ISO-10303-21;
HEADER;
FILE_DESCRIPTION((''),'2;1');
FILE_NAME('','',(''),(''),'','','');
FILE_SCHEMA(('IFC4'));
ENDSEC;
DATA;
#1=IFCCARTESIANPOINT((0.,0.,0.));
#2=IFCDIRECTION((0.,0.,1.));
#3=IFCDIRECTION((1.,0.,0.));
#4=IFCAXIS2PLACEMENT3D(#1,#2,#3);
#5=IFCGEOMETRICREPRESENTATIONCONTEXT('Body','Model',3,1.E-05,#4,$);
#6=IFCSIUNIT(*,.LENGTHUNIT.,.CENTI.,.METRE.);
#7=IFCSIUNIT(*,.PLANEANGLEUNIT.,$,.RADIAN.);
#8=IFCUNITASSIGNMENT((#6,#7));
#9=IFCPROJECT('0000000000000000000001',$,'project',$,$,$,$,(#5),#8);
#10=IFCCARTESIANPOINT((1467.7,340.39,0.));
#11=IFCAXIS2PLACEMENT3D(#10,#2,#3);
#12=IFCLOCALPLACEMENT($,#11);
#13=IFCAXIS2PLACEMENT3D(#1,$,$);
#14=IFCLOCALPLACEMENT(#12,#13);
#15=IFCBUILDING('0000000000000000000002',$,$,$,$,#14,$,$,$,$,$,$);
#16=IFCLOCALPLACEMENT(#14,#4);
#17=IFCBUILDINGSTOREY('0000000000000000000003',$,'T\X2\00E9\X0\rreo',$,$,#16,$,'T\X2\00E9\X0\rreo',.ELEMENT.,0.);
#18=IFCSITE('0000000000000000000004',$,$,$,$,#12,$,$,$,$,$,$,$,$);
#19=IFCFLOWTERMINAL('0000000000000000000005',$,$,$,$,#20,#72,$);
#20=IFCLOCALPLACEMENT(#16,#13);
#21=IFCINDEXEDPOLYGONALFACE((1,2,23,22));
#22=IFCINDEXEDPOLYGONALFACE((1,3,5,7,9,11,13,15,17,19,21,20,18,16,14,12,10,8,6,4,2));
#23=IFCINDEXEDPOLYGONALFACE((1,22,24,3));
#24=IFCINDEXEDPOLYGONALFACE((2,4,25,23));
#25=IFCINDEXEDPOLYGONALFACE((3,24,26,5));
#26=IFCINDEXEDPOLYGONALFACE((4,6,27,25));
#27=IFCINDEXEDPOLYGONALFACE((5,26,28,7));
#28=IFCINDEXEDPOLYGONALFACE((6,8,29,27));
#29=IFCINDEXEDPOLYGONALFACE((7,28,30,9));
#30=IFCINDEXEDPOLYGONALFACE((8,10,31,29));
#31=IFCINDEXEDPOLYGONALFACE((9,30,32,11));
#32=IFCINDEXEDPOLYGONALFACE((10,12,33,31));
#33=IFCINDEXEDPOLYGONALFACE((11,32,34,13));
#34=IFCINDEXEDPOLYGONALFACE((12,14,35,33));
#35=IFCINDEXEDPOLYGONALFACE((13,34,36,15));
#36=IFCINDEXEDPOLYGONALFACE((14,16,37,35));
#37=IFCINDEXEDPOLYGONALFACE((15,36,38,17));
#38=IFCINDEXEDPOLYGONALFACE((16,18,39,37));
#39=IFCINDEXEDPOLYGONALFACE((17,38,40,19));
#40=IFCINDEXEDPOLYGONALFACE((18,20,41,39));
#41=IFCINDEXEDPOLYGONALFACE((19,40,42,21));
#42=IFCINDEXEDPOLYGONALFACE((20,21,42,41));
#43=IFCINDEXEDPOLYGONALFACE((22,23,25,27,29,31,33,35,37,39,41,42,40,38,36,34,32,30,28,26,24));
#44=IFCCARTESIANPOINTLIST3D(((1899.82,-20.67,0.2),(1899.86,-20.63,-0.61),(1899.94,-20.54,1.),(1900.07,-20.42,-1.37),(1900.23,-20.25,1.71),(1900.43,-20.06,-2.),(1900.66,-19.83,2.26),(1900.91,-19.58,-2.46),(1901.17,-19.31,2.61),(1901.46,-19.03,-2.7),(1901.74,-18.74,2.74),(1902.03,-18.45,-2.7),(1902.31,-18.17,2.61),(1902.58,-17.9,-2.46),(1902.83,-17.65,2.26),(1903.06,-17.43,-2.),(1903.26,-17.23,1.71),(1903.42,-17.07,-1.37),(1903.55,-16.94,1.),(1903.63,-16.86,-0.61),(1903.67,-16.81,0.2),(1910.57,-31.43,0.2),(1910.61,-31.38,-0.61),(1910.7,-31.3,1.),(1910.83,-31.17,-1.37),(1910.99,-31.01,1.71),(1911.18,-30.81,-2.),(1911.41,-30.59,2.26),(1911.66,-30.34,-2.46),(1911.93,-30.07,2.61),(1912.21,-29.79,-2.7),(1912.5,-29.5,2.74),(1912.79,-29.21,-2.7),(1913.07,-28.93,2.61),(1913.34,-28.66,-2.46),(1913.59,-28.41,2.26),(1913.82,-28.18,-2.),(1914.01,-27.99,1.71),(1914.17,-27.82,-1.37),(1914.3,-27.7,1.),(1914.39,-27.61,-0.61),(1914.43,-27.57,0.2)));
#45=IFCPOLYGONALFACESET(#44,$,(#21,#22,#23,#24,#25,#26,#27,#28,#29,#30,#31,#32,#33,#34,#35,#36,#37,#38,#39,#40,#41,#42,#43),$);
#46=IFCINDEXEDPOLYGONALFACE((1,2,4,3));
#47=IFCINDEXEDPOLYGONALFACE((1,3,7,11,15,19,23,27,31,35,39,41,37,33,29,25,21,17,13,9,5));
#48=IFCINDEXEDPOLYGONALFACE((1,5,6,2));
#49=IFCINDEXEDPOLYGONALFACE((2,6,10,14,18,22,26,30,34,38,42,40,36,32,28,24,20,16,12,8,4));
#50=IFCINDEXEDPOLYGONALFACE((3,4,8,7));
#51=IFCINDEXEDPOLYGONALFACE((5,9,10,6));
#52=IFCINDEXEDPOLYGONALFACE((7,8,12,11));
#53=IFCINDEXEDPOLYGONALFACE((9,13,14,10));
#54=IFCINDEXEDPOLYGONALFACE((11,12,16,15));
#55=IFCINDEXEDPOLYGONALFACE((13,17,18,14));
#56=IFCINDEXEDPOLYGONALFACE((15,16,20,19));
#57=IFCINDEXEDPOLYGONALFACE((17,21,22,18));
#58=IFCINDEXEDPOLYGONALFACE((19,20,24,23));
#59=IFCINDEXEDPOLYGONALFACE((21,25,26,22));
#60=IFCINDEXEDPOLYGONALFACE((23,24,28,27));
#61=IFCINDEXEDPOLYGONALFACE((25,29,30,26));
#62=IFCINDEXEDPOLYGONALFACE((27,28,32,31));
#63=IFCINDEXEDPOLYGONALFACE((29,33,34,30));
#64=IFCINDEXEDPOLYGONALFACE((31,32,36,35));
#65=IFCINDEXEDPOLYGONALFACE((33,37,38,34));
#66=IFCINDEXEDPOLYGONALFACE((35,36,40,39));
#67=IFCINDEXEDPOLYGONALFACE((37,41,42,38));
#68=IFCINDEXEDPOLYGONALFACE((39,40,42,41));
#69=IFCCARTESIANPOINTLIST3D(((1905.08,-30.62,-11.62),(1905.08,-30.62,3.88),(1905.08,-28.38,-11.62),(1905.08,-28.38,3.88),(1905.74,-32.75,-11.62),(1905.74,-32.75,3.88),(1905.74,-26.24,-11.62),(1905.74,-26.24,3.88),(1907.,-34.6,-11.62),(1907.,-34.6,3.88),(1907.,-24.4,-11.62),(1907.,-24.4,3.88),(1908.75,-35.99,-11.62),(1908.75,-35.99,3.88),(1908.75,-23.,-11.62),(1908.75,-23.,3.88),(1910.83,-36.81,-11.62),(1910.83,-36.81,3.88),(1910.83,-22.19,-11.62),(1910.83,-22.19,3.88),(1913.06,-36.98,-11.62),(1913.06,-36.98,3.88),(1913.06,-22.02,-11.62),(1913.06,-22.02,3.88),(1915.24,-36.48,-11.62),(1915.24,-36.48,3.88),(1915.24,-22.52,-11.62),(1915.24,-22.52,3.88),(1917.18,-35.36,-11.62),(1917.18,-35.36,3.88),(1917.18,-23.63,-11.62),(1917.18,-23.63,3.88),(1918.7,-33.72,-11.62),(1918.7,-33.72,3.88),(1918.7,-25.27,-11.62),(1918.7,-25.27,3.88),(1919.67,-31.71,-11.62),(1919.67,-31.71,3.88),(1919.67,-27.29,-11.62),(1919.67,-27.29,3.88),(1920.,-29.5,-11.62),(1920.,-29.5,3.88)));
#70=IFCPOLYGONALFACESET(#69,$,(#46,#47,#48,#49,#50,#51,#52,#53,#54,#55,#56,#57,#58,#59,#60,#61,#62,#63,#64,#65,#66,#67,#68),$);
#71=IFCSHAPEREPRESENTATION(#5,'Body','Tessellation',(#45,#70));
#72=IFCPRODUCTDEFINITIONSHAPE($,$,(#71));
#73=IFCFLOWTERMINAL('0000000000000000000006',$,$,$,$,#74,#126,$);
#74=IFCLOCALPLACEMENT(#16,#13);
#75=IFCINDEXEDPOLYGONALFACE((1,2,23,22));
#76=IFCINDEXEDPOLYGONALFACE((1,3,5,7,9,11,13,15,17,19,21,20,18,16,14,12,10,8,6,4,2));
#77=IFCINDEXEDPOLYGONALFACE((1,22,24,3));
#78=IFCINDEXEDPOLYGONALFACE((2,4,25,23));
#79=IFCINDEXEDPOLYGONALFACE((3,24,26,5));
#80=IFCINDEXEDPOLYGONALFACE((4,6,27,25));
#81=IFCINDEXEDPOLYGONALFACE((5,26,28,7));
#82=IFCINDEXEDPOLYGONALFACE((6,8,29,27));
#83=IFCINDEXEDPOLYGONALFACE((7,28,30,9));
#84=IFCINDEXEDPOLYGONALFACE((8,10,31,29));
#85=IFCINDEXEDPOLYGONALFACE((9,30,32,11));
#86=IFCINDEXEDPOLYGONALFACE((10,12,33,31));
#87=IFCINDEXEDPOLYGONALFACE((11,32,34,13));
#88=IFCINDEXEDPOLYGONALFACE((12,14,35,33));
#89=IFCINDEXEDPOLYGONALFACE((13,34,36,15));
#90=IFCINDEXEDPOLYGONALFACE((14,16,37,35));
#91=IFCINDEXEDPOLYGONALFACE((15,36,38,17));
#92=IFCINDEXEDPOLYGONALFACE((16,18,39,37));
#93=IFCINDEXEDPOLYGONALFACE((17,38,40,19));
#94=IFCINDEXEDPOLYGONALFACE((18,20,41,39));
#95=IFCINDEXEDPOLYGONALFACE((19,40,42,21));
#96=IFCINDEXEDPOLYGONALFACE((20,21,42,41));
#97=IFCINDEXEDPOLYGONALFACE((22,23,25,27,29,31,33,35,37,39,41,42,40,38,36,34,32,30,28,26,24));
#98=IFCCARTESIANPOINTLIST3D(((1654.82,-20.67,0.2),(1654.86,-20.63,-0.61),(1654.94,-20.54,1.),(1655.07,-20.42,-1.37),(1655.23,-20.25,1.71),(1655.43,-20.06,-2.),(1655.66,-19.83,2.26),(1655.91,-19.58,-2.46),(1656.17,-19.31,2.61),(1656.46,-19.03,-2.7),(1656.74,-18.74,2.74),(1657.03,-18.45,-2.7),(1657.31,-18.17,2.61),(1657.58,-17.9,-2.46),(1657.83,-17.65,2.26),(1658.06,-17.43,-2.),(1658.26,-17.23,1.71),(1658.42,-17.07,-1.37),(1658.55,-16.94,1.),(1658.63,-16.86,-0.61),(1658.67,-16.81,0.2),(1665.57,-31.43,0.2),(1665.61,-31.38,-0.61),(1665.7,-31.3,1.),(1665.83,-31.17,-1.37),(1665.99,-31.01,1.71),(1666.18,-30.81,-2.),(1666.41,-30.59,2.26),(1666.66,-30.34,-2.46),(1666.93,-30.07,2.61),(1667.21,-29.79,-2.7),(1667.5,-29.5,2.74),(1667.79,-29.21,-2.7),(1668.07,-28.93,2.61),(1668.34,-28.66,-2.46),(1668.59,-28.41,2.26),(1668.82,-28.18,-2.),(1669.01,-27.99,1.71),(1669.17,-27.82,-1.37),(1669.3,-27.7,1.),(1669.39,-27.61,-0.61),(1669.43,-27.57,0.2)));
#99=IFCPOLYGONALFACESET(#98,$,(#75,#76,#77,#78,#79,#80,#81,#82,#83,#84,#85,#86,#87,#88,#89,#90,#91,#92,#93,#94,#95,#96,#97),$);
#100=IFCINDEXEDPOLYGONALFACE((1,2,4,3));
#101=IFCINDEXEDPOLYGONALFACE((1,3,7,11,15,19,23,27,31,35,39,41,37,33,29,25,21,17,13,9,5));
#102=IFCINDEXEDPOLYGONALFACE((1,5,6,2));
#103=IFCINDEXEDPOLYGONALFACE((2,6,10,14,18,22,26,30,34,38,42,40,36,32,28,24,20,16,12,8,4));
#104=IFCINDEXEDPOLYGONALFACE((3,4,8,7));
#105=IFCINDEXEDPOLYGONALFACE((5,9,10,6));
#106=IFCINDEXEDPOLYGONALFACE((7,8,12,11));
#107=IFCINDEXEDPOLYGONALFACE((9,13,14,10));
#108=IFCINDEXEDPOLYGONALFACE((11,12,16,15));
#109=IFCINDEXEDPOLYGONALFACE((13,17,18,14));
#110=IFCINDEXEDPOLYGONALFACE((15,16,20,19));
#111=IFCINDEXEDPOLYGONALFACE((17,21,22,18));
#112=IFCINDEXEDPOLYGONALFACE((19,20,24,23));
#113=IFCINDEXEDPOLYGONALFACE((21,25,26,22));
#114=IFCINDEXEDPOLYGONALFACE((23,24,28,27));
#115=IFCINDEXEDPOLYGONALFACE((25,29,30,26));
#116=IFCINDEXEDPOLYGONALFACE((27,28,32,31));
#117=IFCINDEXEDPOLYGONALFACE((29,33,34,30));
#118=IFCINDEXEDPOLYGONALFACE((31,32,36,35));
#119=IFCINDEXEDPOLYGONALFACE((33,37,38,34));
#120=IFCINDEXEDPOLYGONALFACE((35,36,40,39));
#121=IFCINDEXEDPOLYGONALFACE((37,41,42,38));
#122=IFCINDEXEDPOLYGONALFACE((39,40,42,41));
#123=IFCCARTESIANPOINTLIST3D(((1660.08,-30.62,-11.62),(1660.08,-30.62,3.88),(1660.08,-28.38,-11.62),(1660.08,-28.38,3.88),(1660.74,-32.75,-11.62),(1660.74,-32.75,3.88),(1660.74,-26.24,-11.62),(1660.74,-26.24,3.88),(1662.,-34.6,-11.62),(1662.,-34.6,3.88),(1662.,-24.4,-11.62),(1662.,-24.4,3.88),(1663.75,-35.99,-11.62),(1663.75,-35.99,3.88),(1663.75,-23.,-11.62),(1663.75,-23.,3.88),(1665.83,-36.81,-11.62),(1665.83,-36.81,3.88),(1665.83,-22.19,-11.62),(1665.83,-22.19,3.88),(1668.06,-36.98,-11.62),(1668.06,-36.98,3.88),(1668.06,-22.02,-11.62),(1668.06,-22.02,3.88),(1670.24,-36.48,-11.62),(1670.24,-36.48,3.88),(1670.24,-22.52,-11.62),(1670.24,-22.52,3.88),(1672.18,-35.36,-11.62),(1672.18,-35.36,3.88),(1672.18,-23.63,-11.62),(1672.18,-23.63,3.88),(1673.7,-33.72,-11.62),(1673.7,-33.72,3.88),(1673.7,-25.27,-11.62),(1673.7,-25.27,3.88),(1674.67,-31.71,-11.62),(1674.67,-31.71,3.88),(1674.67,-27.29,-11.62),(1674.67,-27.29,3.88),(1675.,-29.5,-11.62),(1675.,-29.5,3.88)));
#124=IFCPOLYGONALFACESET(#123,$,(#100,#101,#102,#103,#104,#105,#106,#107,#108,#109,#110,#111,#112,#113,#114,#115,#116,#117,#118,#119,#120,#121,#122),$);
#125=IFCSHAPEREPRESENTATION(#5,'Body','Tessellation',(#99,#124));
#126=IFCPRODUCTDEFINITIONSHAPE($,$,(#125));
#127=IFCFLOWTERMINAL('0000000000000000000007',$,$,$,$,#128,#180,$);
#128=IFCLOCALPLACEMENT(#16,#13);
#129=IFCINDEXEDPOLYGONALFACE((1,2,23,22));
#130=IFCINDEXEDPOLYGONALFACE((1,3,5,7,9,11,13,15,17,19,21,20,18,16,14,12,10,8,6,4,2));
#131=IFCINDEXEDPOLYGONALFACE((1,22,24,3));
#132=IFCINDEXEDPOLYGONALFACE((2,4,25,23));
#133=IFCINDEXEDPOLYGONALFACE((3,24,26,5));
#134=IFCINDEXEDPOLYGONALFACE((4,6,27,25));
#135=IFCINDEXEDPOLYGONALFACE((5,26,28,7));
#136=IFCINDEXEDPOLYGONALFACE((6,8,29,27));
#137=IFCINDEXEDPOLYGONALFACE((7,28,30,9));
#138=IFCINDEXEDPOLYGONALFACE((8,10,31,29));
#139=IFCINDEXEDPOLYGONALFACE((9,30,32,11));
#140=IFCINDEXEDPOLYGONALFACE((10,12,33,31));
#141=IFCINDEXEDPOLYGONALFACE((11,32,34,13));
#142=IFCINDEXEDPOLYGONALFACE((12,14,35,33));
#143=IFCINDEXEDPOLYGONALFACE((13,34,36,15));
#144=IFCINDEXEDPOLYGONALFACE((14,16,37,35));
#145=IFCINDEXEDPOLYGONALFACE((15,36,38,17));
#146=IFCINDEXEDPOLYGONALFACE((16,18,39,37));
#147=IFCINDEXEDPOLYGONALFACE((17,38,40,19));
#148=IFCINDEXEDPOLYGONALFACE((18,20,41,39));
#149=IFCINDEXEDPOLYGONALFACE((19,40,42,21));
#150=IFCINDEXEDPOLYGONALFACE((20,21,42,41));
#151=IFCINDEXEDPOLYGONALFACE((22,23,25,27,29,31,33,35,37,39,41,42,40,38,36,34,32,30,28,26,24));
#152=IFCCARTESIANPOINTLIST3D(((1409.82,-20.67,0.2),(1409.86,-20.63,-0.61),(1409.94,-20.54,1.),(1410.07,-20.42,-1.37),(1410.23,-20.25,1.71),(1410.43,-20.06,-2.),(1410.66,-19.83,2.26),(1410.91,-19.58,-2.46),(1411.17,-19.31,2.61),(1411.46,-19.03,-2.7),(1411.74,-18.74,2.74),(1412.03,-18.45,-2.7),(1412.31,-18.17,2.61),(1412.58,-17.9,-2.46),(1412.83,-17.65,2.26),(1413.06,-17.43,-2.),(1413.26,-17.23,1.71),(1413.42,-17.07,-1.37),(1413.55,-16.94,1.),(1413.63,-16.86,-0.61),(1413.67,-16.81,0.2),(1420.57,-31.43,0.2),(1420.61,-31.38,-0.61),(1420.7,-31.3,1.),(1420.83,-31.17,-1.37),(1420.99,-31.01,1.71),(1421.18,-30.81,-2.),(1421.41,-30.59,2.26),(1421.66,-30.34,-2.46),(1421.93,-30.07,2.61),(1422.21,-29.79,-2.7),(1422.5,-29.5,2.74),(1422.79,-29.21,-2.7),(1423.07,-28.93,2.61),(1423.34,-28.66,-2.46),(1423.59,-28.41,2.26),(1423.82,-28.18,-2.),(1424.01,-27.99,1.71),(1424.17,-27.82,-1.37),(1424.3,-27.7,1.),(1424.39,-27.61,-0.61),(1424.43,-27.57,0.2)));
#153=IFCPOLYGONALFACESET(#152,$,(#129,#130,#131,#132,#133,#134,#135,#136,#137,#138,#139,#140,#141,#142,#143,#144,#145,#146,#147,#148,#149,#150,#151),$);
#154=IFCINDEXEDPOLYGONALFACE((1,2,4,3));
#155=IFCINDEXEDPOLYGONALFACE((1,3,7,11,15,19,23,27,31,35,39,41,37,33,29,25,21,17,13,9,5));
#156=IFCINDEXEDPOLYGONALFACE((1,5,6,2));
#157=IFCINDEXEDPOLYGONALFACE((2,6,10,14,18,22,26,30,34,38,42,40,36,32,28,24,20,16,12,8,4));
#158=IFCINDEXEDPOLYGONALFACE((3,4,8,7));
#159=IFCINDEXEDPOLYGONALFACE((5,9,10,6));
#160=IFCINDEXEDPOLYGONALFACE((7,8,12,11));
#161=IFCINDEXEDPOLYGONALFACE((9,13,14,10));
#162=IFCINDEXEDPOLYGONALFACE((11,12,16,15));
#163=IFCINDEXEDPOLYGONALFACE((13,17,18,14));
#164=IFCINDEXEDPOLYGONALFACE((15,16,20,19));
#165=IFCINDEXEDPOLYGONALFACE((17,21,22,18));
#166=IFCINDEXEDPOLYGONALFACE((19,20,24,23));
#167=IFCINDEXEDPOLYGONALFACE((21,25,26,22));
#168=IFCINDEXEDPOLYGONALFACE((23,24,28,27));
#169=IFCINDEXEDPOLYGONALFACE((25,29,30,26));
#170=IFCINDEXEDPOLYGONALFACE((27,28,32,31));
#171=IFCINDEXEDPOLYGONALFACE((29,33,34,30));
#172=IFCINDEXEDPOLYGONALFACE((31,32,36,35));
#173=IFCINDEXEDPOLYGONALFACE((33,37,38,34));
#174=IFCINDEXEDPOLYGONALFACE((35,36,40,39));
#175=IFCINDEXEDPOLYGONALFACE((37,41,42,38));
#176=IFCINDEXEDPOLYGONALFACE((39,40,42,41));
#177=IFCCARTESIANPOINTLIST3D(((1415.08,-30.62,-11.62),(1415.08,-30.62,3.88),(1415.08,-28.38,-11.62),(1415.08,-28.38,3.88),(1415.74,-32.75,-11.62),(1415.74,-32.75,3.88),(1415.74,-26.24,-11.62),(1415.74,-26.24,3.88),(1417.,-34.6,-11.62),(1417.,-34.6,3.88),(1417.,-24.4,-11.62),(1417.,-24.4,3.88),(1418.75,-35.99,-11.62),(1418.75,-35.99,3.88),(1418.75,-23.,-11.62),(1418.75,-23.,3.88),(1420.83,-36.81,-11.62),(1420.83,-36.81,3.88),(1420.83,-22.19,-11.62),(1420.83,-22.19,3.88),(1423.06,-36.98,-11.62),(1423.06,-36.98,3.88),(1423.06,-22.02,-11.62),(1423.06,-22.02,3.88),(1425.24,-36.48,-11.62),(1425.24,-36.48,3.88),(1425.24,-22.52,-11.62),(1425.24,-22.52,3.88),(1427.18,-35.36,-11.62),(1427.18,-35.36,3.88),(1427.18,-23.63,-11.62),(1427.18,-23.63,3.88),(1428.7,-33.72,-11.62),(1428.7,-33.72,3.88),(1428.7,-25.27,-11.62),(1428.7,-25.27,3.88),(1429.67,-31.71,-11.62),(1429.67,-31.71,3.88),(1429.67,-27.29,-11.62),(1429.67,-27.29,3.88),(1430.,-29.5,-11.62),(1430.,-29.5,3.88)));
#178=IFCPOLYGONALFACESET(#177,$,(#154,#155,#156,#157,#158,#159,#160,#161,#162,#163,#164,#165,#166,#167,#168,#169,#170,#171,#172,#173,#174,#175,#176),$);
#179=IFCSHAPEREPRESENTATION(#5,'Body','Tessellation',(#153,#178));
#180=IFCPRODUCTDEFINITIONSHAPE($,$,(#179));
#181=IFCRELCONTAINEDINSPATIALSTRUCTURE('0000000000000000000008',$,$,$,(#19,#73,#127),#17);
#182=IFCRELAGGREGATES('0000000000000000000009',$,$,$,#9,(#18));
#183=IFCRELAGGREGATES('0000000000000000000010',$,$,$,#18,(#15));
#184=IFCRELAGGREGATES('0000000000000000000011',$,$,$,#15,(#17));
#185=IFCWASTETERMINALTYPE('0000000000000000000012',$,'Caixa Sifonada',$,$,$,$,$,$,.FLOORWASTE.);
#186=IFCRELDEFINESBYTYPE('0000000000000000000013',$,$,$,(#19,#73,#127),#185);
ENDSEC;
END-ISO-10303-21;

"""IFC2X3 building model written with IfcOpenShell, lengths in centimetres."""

from ifc_helpers import new_model, si_unit, frame, origin, origin_with_axes, origin_2d_with_axis, place, context, project, spatial, circle, extrude, type_object, element, save


model = new_model("IFC2X3")

# Units and contexts
model_context = context("Model", 3, precision=1e-05, world=origin_with_axes(), identifier="Body")
ifc_project = project(units=[si_unit("LENGTHUNIT", "METRE", prefix="CENTI"), si_unit("PLANEANGLEUNIT", "RADIAN")], contexts=[model_context])

# Site, building, storey
site_placement = place(None, frame((1467.7, 340.39, 0.0), z_axis=(0.0, 0.0, 1.0), x_axis=(1.0, 0.0, 0.0)))
site = spatial("IfcSite", under=ifc_project, at=site_placement)
building_placement = place(site_placement, origin())
building = spatial("IfcBuilding", under=site, at=building_placement)
storey_placement = place(building_placement, origin_with_axes())
storey = spatial("IfcBuildingStorey", under=building, at=storey_placement, Name="Térreo", LongName="Térreo", CompositionType="ELEMENT", Elevation=0.0)

# Flow terminals
waste_terminal_type_1 = type_object("IfcWasteTerminalType", Name="Caixa Sifonada", PredefinedType="FLOORWASTE")
flow_terminal_1_placement = place(storey_placement, frame((1909.91, -26.9, 3.88), z_axis=(0.0, 0.0, 1.0), x_axis=(1.0, 0.0, 0.0)))
element("IfcFlowTerminal", 1, at=flow_terminal_1_placement, inside=storey, type_object=waste_terminal_type_1, context=model_context, shape_type="SolidModel", body=[
    extrude(circle(Radius=2.73, at=origin_2d_with_axis()), frame((2.59, -2.59, -3.88), z_axis=(-0.707107, 0.707107, 0.0), x_axis=(0.0, 0.0, 1.0)), (0.0, 0.0, 1.0), 15.21),
    extrude(circle(Radius=7.5, at=origin_2d_with_axis()), frame((2.59, -2.59, -15.5), z_axis=(0.0, 0.0, 1.0), x_axis=(1.0, 0.0, 0.0)), (0.0, 0.0, 1.0), 15.5),
])
flow_terminal_2_placement = place(storey_placement, frame((1664.91, -26.9, 3.88), z_axis=(0.0, 0.0, 1.0), x_axis=(1.0, 0.0, 0.0)))
element("IfcFlowTerminal", 2, at=flow_terminal_2_placement, inside=storey, type_object=waste_terminal_type_1, context=model_context, shape_type="SolidModel", body=[
    extrude(circle(Radius=2.73, at=origin_2d_with_axis()), frame((2.59, -2.59, -3.88), z_axis=(-0.707107, 0.707107, 0.0), x_axis=(0.0, 0.0, 1.0)), (0.0, 0.0, 1.0), 15.21),
    extrude(circle(Radius=7.5, at=origin_2d_with_axis()), frame((2.59, -2.59, -15.5), z_axis=(0.0, 0.0, 1.0), x_axis=(1.0, 0.0, 0.0)), (0.0, 0.0, 1.0), 15.5),
])
flow_terminal_3_placement = place(storey_placement, frame((1419.91, -26.9, 3.88), z_axis=(0.0, 0.0, 1.0), x_axis=(1.0, 0.0, 0.0)))
element("IfcFlowTerminal", 3, at=flow_terminal_3_placement, inside=storey, type_object=waste_terminal_type_1, context=model_context, shape_type="SolidModel", body=[
    extrude(circle(Radius=2.73, at=origin_2d_with_axis()), frame((2.59, -2.59, -3.88), z_axis=(-0.707107, 0.707107, 0.0), x_axis=(0.0, 0.0, 1.0)), (0.0, 0.0, 1.0), 15.21),
    extrude(circle(Radius=7.5, at=origin_2d_with_axis()), frame((2.59, -2.59, -15.5), z_axis=(0.0, 0.0, 1.0), x_axis=(1.0, 0.0, 0.0)), (0.0, 0.0, 1.0), 15.5),
])

save(model, "model.ifc")
